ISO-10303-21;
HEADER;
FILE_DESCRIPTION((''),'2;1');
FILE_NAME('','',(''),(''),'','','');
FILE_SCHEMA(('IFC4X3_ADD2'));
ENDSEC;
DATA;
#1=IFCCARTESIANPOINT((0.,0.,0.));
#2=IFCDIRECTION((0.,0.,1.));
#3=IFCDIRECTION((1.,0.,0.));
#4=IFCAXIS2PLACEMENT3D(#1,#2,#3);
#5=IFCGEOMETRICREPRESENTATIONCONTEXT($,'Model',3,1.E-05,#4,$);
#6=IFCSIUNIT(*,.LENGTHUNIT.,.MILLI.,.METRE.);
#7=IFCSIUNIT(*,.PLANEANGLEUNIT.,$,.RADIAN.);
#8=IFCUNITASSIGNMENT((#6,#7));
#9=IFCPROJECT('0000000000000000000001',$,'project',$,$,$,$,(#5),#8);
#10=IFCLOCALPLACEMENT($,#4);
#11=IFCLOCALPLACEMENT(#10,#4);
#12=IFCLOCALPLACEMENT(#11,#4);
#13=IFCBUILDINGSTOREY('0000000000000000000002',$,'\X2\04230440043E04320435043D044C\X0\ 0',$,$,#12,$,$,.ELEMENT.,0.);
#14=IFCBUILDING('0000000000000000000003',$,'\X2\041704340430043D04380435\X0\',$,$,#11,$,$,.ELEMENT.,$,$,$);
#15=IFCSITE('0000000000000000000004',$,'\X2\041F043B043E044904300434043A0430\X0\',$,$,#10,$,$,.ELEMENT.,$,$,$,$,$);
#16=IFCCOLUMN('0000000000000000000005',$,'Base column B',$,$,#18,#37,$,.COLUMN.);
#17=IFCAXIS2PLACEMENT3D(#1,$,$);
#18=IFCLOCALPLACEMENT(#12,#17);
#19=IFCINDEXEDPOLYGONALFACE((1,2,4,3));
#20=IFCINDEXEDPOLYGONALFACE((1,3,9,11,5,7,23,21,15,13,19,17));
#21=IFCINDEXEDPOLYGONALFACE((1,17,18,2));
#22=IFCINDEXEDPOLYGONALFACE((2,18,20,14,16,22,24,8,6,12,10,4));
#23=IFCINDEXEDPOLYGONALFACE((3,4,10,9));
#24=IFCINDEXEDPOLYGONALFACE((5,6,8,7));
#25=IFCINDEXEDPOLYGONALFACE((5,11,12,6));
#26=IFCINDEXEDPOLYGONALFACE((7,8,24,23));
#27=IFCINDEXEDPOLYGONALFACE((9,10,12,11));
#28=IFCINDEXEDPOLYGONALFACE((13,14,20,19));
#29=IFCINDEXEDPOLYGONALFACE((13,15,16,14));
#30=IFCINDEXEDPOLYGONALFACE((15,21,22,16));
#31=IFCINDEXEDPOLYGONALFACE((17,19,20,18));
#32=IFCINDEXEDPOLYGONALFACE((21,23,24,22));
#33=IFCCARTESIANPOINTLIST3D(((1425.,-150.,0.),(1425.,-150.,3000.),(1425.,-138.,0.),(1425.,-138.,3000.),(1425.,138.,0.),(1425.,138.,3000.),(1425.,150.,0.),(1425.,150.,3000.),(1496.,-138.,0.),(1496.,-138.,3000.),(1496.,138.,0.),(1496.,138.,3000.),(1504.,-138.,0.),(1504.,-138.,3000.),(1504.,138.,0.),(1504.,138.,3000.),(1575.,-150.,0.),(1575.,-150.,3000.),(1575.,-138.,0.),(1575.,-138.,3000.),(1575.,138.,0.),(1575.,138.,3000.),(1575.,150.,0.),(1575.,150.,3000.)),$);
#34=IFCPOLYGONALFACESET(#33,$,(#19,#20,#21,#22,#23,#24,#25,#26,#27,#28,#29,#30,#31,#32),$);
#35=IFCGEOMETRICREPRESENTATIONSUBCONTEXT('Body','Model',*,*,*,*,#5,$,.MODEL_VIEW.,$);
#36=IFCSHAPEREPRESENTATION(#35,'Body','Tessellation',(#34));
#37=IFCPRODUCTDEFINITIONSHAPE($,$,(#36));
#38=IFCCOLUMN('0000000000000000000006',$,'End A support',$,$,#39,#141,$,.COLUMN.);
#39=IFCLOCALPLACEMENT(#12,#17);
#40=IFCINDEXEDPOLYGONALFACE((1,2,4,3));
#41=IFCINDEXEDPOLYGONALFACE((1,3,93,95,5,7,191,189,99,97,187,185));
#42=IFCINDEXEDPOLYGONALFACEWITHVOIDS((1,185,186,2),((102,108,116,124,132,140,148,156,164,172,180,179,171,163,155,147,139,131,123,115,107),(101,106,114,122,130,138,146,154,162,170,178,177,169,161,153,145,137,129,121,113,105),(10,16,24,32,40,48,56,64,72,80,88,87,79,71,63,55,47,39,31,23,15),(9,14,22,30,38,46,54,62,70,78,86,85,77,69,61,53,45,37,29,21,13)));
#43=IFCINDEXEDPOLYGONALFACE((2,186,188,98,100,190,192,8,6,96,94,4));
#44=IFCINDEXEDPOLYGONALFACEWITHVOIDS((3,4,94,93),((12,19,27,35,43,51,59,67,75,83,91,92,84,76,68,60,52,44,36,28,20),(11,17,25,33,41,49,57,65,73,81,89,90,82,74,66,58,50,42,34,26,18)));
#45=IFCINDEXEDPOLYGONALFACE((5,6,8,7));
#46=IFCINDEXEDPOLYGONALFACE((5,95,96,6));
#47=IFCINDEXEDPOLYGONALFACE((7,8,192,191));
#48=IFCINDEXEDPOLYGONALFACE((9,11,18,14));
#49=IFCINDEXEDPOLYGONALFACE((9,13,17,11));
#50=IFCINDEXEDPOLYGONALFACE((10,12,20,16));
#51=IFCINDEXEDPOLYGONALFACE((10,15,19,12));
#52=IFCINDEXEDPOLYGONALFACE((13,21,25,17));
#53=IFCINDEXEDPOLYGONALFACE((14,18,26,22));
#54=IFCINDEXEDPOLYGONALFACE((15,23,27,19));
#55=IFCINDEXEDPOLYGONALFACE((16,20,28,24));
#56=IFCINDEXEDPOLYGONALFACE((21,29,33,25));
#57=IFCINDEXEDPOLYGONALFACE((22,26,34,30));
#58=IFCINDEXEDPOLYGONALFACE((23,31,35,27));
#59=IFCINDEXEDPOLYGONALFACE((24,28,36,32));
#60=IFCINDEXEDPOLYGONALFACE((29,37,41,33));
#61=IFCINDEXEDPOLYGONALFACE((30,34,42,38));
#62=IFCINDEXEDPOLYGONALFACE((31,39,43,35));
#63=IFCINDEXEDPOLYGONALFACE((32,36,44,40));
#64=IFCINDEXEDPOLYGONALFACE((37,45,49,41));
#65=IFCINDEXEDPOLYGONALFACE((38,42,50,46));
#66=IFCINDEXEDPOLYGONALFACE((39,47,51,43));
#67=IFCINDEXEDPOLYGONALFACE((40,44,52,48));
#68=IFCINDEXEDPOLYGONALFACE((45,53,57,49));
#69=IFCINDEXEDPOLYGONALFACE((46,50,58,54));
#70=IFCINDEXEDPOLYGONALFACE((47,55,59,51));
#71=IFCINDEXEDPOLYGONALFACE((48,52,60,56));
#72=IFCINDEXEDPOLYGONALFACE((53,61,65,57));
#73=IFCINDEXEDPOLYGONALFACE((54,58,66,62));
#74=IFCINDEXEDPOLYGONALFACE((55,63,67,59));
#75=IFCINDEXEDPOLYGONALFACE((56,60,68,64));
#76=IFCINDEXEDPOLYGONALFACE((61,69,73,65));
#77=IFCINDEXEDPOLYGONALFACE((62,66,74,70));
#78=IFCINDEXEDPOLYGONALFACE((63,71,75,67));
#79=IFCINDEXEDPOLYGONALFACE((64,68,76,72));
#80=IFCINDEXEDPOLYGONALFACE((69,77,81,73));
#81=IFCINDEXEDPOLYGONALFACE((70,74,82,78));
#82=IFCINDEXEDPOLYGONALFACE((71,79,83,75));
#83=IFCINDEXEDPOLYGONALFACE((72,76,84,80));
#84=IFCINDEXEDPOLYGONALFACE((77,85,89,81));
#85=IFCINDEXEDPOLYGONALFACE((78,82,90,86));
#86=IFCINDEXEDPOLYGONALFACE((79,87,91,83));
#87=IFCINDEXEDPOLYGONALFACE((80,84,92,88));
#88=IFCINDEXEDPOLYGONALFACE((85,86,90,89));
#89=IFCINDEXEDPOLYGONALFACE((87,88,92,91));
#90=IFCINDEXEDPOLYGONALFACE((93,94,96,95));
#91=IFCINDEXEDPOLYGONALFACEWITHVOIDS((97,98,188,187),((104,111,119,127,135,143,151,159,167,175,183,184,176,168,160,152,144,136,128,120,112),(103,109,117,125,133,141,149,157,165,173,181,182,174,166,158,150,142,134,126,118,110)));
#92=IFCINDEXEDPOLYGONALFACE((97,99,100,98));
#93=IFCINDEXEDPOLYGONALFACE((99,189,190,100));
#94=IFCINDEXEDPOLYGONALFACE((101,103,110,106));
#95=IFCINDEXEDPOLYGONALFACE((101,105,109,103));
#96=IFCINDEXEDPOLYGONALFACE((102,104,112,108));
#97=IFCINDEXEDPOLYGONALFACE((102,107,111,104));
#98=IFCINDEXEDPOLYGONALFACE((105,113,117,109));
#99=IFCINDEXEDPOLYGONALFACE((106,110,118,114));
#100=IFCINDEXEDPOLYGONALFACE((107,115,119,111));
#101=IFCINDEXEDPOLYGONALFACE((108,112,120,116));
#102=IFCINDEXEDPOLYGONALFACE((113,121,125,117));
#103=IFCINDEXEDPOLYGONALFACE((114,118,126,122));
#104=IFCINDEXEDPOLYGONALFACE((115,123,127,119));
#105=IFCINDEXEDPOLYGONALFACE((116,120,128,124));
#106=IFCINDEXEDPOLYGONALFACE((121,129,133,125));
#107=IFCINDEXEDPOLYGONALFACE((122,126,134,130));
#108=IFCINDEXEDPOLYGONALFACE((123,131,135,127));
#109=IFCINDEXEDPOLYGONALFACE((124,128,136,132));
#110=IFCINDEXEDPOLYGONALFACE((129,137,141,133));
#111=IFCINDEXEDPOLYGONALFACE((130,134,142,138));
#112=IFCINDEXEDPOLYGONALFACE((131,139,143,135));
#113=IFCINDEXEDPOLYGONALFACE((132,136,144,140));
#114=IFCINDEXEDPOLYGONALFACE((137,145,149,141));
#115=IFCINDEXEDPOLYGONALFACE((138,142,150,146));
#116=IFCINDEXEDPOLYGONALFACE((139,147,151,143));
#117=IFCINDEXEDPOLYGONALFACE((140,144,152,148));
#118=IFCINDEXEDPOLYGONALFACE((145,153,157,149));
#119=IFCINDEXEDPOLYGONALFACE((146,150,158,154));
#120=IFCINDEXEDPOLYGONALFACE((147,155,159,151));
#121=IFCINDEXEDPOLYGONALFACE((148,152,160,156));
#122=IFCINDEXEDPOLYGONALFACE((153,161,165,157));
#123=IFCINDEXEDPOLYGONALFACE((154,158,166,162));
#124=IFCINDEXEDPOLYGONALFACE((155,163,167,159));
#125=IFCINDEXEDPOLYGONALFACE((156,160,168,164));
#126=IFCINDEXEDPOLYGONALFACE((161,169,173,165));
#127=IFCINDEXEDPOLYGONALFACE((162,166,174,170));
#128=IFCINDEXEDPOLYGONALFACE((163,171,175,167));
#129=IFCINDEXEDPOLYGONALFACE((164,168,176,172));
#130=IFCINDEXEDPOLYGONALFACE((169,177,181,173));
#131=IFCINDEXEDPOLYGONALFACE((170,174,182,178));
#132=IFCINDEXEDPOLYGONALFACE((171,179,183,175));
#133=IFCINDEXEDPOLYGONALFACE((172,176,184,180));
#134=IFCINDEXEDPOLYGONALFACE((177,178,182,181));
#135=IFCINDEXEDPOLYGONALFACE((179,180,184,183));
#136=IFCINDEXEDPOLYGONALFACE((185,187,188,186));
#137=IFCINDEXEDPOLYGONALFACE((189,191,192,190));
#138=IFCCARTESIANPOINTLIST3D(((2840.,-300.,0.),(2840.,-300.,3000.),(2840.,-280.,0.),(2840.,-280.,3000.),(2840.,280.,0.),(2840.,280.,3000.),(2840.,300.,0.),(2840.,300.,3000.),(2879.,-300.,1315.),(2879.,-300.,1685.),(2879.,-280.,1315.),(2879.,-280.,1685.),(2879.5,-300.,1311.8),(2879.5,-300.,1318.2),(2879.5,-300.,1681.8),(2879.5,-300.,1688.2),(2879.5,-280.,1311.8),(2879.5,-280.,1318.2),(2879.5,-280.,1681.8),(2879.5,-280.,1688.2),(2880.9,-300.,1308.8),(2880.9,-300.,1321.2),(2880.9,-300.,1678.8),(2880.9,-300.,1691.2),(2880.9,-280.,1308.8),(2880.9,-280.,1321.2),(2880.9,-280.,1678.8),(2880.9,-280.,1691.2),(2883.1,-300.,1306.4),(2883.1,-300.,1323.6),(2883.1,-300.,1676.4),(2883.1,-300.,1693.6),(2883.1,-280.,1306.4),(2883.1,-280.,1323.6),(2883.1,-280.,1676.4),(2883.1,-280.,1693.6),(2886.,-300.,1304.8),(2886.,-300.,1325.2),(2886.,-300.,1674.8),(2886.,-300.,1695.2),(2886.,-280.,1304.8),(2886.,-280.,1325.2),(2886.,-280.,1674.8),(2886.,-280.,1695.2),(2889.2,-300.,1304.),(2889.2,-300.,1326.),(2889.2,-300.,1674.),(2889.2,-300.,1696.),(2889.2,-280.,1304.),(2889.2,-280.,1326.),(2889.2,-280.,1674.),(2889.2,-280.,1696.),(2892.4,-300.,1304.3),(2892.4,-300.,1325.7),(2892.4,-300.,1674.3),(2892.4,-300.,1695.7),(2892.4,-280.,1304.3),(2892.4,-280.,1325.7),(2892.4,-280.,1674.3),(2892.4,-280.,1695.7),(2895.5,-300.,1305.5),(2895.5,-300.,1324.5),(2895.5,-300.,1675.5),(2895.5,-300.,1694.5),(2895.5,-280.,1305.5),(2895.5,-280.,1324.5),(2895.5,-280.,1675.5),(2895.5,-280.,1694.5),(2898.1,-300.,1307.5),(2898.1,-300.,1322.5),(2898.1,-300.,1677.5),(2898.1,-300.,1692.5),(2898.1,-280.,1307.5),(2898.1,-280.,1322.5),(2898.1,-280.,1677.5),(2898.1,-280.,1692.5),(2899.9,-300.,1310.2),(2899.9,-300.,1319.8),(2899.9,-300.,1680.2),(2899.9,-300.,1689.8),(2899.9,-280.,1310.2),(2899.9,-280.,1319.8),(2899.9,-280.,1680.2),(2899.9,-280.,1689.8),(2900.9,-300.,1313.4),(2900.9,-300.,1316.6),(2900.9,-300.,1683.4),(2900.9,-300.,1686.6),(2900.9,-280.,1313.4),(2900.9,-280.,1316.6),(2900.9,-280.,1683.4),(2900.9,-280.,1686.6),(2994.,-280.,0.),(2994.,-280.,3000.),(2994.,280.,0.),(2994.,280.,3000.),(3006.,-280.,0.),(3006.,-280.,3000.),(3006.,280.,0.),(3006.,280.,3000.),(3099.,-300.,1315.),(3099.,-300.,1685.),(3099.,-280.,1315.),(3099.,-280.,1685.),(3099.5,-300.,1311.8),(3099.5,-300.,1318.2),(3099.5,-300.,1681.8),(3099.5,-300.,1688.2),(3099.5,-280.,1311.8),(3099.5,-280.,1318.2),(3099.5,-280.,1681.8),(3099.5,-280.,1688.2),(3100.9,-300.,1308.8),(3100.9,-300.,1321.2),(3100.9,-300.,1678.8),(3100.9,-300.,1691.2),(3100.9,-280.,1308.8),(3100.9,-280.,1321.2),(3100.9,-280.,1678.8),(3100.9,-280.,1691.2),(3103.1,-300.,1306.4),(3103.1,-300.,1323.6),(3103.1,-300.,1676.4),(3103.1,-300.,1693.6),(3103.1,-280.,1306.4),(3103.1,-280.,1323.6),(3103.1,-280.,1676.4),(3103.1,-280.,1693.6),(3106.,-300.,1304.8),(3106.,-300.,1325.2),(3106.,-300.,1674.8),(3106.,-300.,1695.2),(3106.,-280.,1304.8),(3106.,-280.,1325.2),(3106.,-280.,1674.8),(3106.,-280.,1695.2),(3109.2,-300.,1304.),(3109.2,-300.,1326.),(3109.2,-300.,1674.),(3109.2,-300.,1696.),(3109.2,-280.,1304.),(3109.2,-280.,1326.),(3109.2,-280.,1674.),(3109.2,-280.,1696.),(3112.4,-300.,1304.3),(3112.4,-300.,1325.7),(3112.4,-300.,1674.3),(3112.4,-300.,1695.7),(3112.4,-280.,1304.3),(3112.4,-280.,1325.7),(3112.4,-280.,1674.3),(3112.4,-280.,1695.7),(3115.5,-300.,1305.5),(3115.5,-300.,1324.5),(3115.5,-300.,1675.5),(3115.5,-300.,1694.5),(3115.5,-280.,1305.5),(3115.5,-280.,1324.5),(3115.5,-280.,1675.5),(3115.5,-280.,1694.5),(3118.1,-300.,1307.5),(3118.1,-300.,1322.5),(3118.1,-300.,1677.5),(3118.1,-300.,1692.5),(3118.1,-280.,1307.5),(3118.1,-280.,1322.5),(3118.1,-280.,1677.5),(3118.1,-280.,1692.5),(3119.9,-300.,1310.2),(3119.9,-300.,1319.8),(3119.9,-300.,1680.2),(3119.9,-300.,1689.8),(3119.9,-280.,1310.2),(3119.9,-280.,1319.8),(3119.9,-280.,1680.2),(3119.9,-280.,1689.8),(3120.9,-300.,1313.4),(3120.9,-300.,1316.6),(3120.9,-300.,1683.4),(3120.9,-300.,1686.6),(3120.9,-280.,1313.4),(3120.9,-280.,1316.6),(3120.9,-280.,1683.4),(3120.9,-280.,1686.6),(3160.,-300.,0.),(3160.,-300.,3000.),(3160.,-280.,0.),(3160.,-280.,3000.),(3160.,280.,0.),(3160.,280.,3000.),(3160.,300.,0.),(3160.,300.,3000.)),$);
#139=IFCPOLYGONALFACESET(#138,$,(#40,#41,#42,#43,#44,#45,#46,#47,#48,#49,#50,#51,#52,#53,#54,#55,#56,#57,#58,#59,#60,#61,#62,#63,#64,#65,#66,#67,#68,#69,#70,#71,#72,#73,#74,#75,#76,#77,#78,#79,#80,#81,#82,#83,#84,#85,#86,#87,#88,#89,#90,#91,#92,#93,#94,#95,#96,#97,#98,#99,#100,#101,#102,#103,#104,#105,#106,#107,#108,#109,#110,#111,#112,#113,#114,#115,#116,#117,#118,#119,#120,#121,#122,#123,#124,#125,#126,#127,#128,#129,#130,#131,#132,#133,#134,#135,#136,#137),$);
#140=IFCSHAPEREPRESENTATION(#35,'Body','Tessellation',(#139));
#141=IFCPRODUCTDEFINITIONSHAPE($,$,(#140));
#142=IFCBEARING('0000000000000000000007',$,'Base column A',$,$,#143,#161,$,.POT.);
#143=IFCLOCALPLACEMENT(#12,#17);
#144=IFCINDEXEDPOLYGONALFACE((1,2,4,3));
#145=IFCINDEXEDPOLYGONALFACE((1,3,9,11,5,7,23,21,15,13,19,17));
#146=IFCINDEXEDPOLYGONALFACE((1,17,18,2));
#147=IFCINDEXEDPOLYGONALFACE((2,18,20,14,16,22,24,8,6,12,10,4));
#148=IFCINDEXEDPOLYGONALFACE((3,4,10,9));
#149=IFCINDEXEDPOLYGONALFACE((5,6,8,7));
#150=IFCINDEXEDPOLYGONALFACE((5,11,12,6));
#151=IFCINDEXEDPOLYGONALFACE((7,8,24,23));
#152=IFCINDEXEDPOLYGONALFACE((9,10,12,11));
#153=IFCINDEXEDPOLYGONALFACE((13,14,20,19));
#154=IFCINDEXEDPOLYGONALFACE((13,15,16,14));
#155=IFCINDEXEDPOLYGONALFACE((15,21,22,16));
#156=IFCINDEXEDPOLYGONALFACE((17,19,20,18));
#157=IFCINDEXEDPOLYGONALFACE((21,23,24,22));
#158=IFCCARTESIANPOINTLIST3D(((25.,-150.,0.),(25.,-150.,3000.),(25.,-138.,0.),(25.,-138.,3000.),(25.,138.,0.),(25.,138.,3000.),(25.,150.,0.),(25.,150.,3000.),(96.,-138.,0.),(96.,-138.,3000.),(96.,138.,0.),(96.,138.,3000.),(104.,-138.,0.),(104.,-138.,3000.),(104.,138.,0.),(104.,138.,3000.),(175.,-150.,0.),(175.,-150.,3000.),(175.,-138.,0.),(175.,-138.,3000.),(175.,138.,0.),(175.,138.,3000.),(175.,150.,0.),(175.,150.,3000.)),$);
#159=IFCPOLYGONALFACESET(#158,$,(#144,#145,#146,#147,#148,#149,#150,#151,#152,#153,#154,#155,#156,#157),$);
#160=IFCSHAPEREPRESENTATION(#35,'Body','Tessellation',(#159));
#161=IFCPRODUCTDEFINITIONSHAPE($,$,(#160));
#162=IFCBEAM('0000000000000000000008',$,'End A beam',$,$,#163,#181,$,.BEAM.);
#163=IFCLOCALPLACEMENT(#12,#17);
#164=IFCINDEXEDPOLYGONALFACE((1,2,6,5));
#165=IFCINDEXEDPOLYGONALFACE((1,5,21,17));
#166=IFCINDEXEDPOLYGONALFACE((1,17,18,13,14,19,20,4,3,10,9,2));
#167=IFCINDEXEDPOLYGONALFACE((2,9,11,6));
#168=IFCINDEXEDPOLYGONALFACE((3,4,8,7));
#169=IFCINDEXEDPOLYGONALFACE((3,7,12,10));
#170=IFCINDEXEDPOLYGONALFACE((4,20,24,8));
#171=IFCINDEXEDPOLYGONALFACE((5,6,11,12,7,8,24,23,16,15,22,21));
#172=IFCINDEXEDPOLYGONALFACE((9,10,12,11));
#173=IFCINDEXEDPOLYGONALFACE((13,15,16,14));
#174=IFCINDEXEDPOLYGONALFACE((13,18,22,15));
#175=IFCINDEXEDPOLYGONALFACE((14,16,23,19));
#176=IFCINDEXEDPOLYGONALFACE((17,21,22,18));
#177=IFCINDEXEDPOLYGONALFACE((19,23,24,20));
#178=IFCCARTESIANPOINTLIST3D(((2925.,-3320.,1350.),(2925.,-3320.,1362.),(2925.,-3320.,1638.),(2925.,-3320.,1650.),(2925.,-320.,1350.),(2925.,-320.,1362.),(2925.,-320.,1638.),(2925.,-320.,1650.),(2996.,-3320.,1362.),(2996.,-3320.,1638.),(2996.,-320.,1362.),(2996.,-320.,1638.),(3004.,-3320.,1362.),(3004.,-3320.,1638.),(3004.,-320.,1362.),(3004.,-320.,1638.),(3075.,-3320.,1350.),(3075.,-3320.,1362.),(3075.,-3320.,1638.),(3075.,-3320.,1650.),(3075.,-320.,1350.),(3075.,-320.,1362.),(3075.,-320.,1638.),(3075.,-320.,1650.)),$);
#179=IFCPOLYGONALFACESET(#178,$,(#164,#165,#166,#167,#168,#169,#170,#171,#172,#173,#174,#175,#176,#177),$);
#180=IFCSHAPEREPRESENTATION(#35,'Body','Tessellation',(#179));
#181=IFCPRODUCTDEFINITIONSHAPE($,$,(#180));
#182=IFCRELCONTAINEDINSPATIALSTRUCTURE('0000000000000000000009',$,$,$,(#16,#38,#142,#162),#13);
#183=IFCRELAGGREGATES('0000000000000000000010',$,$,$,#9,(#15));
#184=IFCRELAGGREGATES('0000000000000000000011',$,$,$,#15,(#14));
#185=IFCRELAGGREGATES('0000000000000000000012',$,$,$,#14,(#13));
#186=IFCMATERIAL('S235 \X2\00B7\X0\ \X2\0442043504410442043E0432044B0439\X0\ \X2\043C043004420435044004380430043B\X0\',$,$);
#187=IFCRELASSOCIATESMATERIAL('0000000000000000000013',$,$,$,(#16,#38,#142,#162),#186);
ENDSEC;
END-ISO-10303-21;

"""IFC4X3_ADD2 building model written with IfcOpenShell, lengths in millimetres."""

from ifc_helpers import new_model, si_unit, frame, origin_with_axes, place, context, subcontext, project, spatial, circle, i_section, extrude, material, element, save


model = new_model("IFC4X3_ADD2")

# Units and contexts
model_context = context("Model", 3, precision=1e-05, world=origin_with_axes())
body_context = subcontext(model_context, "Body", "Model", "MODEL_VIEW")
ifc_project = project(units=[si_unit("LENGTHUNIT", "METRE", prefix="MILLI"), si_unit("PLANEANGLEUNIT", "RADIAN")], contexts=[model_context])

# Site, building, storey
site_placement = place(None, origin_with_axes())
site = spatial("IfcSite", under=ifc_project, at=site_placement, Name="Площадка", CompositionType="ELEMENT")
building_placement = place(site_placement, origin_with_axes())
building = spatial("IfcBuilding", under=site, at=building_placement, Name="Здание", CompositionType="ELEMENT")
storey_placement = place(building_placement, origin_with_axes())
storey = spatial("IfcBuildingStorey", under=building, at=storey_placement, Name="Уровень 0", CompositionType="ELEMENT", Elevation=0.0)

# Column
ifc_material = material(Name="S235 · тестовый материал")
column_1_placement = place(storey_placement, frame((1500.0, 0.0, 0.0), z_axis=(0.0, 0.0, 1.0), x_axis=(1.0, 0.0, 0.0)))
element("IfcColumn", 1, at=column_1_placement, inside=storey, material=ifc_material, Name="Base column B", PredefinedType="COLUMN", context=body_context, shape_type="SweptSolid", body=[
    extrude(i_section(OverallWidth=150.0, OverallDepth=300.0, WebThickness=8.0, FlangeThickness=12.0), origin_with_axes(), (0.0, 0.0, 1.0), 3000.0),
])

# Column, openings
column_2_placement = place(storey_placement, frame((3000.0, 0.0, 0.0), z_axis=(0.0, 0.0, 1.0), x_axis=(1.0, 0.0, 0.0)))
column_2 = element("IfcColumn", 2, at=column_2_placement, inside=storey, material=ifc_material, Name="End A support", PredefinedType="COLUMN", context=body_context, shape_type="SweptSolid", body=[
    extrude(i_section(OverallWidth=320.0, OverallDepth=600.0, WebThickness=12.0, FlangeThickness=20.0), origin_with_axes(), (0.0, 0.0, 1.0), 3000.0),
])
opening_1_placement = place(column_2_placement, frame((110.0, -321.0, 1315.0), z_axis=(0.0, 1.0, 0.0), x_axis=(-1.0, 0.0, 0.0)))
element("IfcOpeningElement", 3, at=opening_1_placement, cuts=column_2, PredefinedType="OPENING", context=body_context, shape_type="SweptSolid", body=[
    extrude(circle(Radius=11.0), origin_with_axes(), (0.0, 0.0, 1.0), 42.0),
])
opening_2_placement = place(column_2_placement, frame((110.0, -321.0, 1685.0), z_axis=(0.0, 1.0, 0.0), x_axis=(-1.0, 0.0, 0.0)))
element("IfcOpeningElement", 4, at=opening_2_placement, cuts=column_2, PredefinedType="OPENING", context=body_context, shape_type="SweptSolid", body=[
    extrude(circle(Radius=11.0), origin_with_axes(), (0.0, 0.0, 1.0), 42.0),
])
opening_3_placement = place(column_2_placement, frame((-110.0, -321.0, 1315.0), z_axis=(0.0, 1.0, 0.0), x_axis=(-1.0, 0.0, 0.0)))
element("IfcOpeningElement", 5, at=opening_3_placement, cuts=column_2, PredefinedType="OPENING", context=body_context, shape_type="SweptSolid", body=[
    extrude(circle(Radius=11.0), origin_with_axes(), (0.0, 0.0, 1.0), 42.0),
])
opening_4_placement = place(column_2_placement, frame((-110.0, -321.0, 1685.0), z_axis=(0.0, 1.0, 0.0), x_axis=(-1.0, 0.0, 0.0)))
element("IfcOpeningElement", 6, at=opening_4_placement, cuts=column_2, PredefinedType="OPENING", context=body_context, shape_type="SweptSolid", body=[
    extrude(circle(Radius=11.0), origin_with_axes(), (0.0, 0.0, 1.0), 42.0),
])

# Bearing
bearing_placement = place(storey_placement, frame((100.0, 0.0, 0.0), z_axis=(0.0, 0.0, 1.0), x_axis=(1.0, 0.0, 0.0)))
element("IfcBearing", 7, at=bearing_placement, inside=storey, material=ifc_material, Name="Base column A", PredefinedType="POT", context=body_context, shape_type="SweptSolid", body=[
    extrude(i_section(OverallWidth=150.0, OverallDepth=300.0, WebThickness=8.0, FlangeThickness=12.0), origin_with_axes(), (0.0, 0.0, 1.0), 3000.0),
])

# Beam
beam_1_placement = place(storey_placement, frame((3000.0, -3320.0, 1500.0), z_axis=(0.0, 1.0, 0.0), x_axis=(-1.0, 0.0, 0.0)))
element("IfcBeam", 8, at=beam_1_placement, inside=storey, material=ifc_material, Name="End A beam", PredefinedType="BEAM", context=body_context, shape_type="SweptSolid", body=[
    extrude(i_section(OverallWidth=150.0, OverallDepth=300.0, WebThickness=8.0, FlangeThickness=12.0), origin_with_axes(), (0.0, 0.0, 1.0), 3000.0),
])

save(model, "model.ifc")
